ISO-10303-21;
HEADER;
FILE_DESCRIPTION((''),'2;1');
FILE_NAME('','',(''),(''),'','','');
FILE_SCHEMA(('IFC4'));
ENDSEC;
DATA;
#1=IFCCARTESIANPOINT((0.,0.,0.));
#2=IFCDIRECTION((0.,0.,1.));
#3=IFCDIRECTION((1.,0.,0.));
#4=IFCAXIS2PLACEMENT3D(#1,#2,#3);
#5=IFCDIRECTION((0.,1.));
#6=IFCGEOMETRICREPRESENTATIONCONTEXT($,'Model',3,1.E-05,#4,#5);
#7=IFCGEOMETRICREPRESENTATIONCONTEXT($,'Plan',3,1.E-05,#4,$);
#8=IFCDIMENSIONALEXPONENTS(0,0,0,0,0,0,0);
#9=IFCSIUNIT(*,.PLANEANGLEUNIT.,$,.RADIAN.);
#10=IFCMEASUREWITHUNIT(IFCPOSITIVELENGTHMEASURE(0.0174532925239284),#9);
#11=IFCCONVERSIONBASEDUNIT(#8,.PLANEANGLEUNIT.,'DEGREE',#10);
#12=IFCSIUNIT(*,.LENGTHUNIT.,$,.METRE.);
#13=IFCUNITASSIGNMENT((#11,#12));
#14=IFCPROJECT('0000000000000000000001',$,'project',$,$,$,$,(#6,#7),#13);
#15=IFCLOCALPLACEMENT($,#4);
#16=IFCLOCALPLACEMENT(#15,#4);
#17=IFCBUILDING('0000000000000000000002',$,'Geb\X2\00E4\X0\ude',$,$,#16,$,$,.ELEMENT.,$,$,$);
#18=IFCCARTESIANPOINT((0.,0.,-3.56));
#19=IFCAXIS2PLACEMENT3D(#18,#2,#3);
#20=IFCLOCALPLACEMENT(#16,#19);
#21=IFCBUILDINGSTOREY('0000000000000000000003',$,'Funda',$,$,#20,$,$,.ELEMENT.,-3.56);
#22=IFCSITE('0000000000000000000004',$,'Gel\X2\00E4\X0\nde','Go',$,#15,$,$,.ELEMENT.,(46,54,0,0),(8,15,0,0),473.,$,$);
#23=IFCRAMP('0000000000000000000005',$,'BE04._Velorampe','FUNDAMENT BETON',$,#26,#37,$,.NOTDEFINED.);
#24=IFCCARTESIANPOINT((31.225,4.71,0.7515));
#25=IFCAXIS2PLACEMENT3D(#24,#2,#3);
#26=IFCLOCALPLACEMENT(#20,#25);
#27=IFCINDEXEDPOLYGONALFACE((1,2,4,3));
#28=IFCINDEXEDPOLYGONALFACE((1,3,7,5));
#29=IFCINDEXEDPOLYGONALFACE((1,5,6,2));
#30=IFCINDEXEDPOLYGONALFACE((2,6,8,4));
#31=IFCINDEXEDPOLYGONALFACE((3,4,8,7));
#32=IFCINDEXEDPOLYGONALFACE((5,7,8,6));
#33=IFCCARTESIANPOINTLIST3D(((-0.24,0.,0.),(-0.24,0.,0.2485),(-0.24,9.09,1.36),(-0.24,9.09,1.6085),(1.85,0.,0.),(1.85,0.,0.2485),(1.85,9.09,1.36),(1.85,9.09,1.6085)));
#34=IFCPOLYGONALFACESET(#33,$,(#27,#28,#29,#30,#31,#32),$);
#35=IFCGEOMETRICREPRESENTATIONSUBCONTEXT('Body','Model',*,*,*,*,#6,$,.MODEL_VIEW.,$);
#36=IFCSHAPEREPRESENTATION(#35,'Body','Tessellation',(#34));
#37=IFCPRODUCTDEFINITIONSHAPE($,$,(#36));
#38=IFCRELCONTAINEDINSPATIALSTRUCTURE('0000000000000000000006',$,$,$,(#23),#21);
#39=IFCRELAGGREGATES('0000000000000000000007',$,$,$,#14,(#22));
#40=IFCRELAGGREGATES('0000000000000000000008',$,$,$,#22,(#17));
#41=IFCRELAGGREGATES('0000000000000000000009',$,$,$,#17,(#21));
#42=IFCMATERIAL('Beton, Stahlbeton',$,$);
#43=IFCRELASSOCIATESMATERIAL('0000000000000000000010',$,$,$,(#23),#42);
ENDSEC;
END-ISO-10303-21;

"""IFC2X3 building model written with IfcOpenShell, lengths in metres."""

from ifc_helpers import new_model, entity, si_unit, converted_unit, direction, frame, origin_with_axes, place, context, subcontext, project, spatial, polyline, outline, extrude, material, element, save


model = new_model("IFC2X3")

# Units and contexts
model_context = context("Model", 3, precision=1e-05, world=origin_with_axes(), true_north=direction((0.0, 1.0)))
plan_context = context("Plan", 3, precision=1e-05, world=origin_with_axes())
body_context = subcontext(model_context, "Body", "Model", "MODEL_VIEW")
ifc_project = project(units=[converted_unit("PLANEANGLEUNIT", "DEGREE", entity("IfcPositiveLengthMeasure", 0.0174532925239284), si_unit("PLANEANGLEUNIT", "RADIAN"), dimensions=[0, 0, 0, 0, 0, 0, 0]), si_unit("LENGTHUNIT", "METRE")], contexts=[model_context, plan_context])

# Site, building, storey
site_placement = place(None, origin_with_axes())
site = spatial("IfcSite", under=ifc_project, at=site_placement, Name="Gelände", Description="Go", CompositionType="ELEMENT", RefLatitude=(46, 54, 0, 0), RefLongitude=(8, 15, 0, 0), RefElevation=473.0)
building_placement = place(site_placement, origin_with_axes())
building = spatial("IfcBuilding", under=site, at=building_placement, Name="Gebäude", CompositionType="ELEMENT")
storey_placement = place(building_placement, frame((0.0, 0.0, -3.56), z_axis=(0.0, 0.0, 1.0), x_axis=(1.0, 0.0, 0.0)))
storey = spatial("IfcBuildingStorey", under=building, at=storey_placement, Name="Funda", CompositionType="ELEMENT", Elevation=-3.56)

# Shared definitions
ifc_material = material(Name="Beton, Stahlbeton")

# Ramp
ramp_placement = place(storey_placement, frame((31.225, 4.71, 0.7515), z_axis=(0.0, 0.0, 1.0), x_axis=(1.0, 0.0, 0.0)))
element("IfcRamp", 1, at=ramp_placement, inside=storey, material=ifc_material, Name="BE04._Velorampe", Description="FUNDAMENT BETON", ShapeType="NOTDEFINED", context=body_context, shape_type="SweptSolid", body=[
    extrude(outline(polyline([(-0.24, 0.0), (1.85, 0.0), (1.85, 9.1912), (-0.24, 9.1912), (-0.24, 0.0)])), frame((0.0, 0.0, 0.0), z_axis=(0.0, -0.147968, 0.988992), x_axis=(1.0, 0.0, 0.0)), (0.0, 0.147968, 0.988992), 0.2485),
])

save(model, "model.ifc")
